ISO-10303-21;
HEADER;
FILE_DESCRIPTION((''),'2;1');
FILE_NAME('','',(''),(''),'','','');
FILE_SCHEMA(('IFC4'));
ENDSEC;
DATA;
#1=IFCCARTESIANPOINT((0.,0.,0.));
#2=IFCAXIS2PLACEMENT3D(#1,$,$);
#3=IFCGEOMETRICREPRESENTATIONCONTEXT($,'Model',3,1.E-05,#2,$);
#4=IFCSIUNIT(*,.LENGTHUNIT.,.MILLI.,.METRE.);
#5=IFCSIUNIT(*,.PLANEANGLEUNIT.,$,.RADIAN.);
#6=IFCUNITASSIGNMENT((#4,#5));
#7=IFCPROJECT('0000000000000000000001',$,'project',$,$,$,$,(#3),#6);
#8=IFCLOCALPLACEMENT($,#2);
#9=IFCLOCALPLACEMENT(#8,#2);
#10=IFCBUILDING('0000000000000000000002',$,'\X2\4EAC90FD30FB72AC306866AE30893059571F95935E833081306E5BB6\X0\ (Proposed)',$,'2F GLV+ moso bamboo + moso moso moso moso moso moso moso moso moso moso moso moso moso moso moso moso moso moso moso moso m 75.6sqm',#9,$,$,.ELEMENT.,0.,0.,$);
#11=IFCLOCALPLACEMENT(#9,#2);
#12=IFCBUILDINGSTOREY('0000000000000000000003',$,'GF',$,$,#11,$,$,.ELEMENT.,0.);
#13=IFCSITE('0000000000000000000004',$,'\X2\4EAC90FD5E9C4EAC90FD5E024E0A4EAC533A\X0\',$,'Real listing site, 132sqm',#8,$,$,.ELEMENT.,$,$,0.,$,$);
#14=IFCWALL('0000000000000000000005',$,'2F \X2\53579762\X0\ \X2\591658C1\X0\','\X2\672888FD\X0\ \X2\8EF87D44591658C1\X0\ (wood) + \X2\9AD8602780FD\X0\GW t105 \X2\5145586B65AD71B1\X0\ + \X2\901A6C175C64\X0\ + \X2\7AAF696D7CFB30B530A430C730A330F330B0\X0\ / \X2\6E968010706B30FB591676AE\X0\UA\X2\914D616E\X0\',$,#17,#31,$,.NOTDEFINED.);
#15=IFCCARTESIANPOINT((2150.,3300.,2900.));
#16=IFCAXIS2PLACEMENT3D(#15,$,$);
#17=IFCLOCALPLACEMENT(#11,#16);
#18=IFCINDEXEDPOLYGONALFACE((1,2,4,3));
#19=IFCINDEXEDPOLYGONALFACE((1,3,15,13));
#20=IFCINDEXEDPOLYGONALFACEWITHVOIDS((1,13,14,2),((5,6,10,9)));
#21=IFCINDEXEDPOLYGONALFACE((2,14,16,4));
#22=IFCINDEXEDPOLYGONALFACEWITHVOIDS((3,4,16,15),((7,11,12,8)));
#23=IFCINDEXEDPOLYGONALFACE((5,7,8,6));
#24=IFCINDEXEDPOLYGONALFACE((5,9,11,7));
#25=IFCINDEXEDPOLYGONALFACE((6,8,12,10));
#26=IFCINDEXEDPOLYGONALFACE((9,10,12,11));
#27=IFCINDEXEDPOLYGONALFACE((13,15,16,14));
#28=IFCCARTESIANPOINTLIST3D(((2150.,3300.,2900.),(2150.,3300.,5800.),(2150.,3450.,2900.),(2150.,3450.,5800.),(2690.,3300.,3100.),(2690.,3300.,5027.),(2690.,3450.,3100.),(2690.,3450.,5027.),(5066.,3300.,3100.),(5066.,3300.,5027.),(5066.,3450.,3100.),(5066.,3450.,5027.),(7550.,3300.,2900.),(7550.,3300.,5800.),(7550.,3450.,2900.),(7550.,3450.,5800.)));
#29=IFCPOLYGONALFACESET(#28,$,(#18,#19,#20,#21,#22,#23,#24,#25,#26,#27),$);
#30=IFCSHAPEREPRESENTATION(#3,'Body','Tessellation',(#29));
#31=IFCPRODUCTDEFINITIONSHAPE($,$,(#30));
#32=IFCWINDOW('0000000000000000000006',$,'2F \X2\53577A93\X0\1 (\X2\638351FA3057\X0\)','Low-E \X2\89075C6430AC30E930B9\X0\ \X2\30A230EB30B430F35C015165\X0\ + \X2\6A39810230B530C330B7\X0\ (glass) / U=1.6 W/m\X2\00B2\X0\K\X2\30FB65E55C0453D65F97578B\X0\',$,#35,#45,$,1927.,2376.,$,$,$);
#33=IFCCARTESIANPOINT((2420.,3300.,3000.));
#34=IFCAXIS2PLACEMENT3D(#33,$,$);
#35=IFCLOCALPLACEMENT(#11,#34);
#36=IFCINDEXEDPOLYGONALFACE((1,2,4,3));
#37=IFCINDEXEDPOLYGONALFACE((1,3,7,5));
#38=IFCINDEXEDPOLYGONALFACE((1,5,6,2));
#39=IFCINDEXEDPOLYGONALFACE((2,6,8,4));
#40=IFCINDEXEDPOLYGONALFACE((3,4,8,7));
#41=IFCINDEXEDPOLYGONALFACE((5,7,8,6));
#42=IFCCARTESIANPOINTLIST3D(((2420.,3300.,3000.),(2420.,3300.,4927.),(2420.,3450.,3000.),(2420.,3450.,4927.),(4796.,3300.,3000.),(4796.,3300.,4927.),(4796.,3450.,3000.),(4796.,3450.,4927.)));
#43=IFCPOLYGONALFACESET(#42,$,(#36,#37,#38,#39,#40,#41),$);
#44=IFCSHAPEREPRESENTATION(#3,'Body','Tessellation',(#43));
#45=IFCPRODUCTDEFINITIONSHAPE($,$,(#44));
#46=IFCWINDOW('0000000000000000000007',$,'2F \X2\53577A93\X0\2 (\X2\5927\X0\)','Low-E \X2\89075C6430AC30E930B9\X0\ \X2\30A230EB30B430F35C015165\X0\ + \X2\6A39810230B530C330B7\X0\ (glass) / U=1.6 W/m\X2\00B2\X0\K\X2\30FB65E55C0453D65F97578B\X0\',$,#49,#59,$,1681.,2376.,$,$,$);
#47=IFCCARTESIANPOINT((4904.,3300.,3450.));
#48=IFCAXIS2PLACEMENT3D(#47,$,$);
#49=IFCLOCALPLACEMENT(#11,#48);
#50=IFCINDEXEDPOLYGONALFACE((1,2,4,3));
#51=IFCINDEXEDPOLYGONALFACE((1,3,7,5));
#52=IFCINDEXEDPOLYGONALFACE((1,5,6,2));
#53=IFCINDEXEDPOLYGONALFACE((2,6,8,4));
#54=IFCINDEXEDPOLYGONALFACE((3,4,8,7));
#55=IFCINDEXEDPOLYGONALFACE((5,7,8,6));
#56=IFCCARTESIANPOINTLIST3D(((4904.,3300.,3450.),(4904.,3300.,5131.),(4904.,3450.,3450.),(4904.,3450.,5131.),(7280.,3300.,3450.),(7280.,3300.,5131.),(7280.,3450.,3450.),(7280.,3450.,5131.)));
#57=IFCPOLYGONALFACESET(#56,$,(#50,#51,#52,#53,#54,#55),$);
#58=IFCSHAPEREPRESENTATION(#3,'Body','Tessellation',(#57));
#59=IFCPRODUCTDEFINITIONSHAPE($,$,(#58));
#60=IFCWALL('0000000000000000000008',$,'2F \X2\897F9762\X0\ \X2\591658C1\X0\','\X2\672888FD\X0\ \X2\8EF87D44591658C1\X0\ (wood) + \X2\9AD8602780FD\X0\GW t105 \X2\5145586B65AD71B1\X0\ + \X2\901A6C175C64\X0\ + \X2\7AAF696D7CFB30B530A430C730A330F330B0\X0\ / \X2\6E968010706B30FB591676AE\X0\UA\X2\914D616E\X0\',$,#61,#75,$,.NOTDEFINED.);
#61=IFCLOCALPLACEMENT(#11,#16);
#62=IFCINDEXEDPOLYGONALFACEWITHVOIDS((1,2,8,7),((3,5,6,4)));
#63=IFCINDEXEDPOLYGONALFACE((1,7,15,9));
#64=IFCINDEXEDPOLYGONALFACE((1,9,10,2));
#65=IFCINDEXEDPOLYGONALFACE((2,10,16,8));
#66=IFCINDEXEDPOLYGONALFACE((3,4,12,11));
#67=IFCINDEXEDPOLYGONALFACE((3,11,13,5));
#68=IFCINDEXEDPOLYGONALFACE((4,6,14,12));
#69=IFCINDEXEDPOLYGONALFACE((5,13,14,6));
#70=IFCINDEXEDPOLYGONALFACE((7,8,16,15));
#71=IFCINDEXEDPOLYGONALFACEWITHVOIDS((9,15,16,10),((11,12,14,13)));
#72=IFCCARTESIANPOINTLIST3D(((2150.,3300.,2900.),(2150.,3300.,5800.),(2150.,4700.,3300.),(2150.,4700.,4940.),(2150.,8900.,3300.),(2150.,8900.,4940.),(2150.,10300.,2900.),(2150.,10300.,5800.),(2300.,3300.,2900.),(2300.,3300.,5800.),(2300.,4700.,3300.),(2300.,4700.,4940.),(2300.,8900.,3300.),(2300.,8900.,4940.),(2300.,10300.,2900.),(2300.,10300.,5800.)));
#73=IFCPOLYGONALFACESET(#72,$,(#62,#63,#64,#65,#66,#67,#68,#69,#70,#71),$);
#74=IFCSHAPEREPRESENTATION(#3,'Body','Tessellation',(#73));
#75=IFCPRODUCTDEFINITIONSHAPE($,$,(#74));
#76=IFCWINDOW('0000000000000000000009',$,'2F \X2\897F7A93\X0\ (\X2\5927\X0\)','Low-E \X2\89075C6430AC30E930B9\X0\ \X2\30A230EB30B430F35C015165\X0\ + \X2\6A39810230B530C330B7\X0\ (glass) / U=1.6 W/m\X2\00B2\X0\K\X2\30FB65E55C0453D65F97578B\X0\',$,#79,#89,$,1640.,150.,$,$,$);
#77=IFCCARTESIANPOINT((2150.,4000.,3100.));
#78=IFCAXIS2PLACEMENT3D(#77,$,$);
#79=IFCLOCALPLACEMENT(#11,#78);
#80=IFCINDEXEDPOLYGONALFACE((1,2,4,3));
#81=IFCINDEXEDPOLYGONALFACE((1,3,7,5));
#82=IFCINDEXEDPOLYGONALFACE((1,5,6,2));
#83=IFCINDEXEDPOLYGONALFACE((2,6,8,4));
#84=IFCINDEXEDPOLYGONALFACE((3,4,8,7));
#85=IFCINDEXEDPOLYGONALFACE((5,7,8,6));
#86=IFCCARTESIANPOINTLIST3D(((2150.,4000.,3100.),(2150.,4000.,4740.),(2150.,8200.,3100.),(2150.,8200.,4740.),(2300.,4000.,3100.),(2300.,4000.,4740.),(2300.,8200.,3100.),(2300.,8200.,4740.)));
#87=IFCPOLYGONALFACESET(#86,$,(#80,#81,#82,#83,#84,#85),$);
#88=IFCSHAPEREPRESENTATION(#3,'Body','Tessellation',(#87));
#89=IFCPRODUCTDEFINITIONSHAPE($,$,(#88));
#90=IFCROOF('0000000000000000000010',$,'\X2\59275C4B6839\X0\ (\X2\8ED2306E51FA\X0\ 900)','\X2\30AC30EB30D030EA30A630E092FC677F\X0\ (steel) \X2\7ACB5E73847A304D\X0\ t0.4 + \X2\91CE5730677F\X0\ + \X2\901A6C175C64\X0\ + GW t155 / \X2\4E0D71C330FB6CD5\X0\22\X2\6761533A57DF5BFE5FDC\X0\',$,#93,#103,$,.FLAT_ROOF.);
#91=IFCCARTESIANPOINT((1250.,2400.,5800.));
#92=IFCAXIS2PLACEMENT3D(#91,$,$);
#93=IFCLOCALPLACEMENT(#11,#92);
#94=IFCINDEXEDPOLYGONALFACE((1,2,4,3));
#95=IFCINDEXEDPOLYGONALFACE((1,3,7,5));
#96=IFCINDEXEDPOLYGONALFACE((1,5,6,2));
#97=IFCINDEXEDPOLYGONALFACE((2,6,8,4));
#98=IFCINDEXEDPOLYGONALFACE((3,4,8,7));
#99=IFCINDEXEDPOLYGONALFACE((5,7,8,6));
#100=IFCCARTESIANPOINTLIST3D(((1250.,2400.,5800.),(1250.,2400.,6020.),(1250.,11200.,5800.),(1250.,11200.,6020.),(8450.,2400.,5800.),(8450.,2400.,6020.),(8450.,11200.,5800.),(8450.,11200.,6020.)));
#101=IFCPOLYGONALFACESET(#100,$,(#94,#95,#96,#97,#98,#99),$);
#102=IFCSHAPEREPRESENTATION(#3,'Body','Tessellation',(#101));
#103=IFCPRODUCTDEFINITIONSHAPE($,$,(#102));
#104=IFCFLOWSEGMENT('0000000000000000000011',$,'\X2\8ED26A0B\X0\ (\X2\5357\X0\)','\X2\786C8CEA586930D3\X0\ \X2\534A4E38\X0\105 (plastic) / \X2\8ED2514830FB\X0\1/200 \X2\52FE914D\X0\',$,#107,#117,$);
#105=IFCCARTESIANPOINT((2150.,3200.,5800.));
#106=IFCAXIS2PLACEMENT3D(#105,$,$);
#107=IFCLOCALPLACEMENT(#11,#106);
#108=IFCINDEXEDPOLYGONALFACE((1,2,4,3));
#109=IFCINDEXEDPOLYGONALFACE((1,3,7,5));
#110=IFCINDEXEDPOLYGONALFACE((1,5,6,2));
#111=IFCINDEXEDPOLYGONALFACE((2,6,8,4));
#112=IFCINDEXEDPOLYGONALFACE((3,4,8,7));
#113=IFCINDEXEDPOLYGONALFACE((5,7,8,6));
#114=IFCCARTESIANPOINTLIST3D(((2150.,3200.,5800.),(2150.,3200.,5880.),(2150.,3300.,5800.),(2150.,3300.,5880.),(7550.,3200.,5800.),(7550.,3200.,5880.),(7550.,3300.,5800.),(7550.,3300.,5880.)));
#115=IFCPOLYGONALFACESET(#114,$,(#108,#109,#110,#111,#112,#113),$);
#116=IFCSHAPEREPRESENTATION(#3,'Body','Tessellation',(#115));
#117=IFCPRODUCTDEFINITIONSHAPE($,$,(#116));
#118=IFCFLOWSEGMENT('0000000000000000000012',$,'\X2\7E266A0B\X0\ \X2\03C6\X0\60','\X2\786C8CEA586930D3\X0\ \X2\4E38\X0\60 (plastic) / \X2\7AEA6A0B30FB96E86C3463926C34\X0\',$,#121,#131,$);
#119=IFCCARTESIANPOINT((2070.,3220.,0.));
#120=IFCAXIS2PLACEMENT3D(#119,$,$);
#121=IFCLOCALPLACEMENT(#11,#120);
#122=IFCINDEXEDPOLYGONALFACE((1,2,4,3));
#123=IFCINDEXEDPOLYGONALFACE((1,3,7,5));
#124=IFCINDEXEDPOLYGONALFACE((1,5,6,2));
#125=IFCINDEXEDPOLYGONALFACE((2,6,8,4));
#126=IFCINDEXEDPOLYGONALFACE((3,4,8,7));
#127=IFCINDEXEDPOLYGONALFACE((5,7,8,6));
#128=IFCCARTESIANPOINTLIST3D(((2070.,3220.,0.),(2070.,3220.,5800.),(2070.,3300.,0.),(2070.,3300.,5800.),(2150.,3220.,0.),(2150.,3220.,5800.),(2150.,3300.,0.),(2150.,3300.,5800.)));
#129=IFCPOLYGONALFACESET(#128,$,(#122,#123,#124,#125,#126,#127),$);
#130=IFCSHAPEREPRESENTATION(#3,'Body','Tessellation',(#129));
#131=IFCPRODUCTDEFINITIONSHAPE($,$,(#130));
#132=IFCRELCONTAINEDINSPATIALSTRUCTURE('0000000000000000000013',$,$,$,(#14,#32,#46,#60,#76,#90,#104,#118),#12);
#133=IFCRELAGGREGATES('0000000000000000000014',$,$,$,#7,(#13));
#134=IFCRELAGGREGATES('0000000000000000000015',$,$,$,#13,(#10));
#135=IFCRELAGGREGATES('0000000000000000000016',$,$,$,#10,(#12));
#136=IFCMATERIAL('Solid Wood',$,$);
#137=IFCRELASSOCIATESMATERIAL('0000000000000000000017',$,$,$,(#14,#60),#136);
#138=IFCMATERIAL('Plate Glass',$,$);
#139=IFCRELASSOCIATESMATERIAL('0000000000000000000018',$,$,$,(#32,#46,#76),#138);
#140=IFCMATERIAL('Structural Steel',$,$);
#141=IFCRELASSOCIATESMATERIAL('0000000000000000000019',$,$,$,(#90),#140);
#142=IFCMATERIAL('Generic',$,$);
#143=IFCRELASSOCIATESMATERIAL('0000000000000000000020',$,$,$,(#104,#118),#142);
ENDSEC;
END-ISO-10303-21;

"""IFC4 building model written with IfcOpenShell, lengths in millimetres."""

from ifc_helpers import new_model, si_unit, frame, frame_2d, origin, place, context, project, spatial, rectangle, extrude, material, element, fill, save


model = new_model("IFC4")

# Units and contexts
model_context = context("Model", 3, precision=1e-05, world=origin())
ifc_project = project(units=[si_unit("LENGTHUNIT", "METRE", prefix="MILLI"), si_unit("PLANEANGLEUNIT", "RADIAN")], contexts=[model_context])

# Site, building, storey
site_placement = place(None, origin())
site = spatial("IfcSite", under=ifc_project, at=site_placement, Name="京都府京都市上京区", ObjectType="Real listing site, 132sqm", CompositionType="ELEMENT", RefElevation=0.0)
building_placement = place(site_placement, origin())
building = spatial("IfcBuilding", under=site, at=building_placement, Name="京都・犬と暮らす土間広めの家 (Proposed)", ObjectType="2F GLV+ moso bamboo + moso moso moso moso moso moso moso moso moso moso moso moso moso moso moso moso moso moso moso moso m 75.6sqm", CompositionType="ELEMENT", ElevationOfRefHeight=0.0, ElevationOfTerrain=0.0)
storey_placement = place(building_placement, origin())
storey = spatial("IfcBuildingStorey", under=building, at=storey_placement, Name="GF", CompositionType="ELEMENT", Elevation=0.0)

# Shared definitions
ifc_material_1 = material(Name="Solid Wood")

# Shared definitions
ifc_material_2 = material(Name="Plate Glass")

# Wall, openings, windows
wall_1_placement = place(storey_placement, frame((2150.0, 3300.0, 2900.0)))
wall_1 = element("IfcWall", 1, at=wall_1_placement, inside=storey, material=ifc_material_1, Name="2F 南面 外壁", Description="木製 軸組外壁 (wood) + 高性能GW t105 充填断熱 + 通気層 + 窯業系サイディング / 準耐火・外皮UA配慮", PredefinedType="NOTDEFINED", context=model_context, shape_type="SweptSolid", body=[
    extrude(rectangle(XDim=5400.0, YDim=150.0, at=frame_2d((2700.0, 75.0))), frame((2150.0, 3300.0, 2900.0)), (0.0, 0.0, 1.0), 2900.0),
])
opening_1_placement = place(storey_placement, frame((2420.0, 3300.0, 3000.0)))
opening_1 = element("IfcOpeningElement", 2, at=opening_1_placement, cuts=wall_1, PredefinedType="NOTDEFINED", context=model_context, shape_type="SweptSolid", body=[
    extrude(rectangle(XDim=2376.0, YDim=150.0, at=frame_2d((1188.0, 75.0))), frame((2420.0, 3300.0, 3000.0)), (0.0, 0.0, 1.0), 1927.0),
])
opening_2_placement = place(storey_placement, frame((4904.0, 3300.0, 3450.0)))
opening_2 = element("IfcOpeningElement", 3, at=opening_2_placement, cuts=wall_1, PredefinedType="NOTDEFINED", context=model_context, shape_type="SweptSolid", body=[
    extrude(rectangle(XDim=2376.0, YDim=150.0, at=frame_2d((1188.0, 75.0))), frame((4904.0, 3300.0, 3450.0)), (0.0, 0.0, 1.0), 1681.0),
])
window_1_placement = place(storey_placement, frame((2420.0, 3300.0, 3000.0)))
window_1 = element("IfcWindow", 4, at=window_1_placement, inside=storey, material=ifc_material_2, Name="2F 南窓1 (掃出し)", Description="Low-E 複層ガラス アルゴン封入 + 樹脂サッシ (glass) / U=1.6 W/m²K・日射取得型", OverallHeight=1927.0, OverallWidth=2376.0, context=model_context, shape_type="SweptSolid", body=[
    extrude(rectangle(XDim=2376.0, YDim=150.0, at=frame_2d((1188.0, 75.0))), frame((2420.0, 3300.0, 3000.0)), (0.0, 0.0, 1.0), 1927.0),
])
fill(opening_1, window_1)
window_2_placement = place(storey_placement, frame((4904.0, 3300.0, 3450.0)))
window_2 = element("IfcWindow", 5, at=window_2_placement, inside=storey, material=ifc_material_2, Name="2F 南窓2 (大)", Description="Low-E 複層ガラス アルゴン封入 + 樹脂サッシ (glass) / U=1.6 W/m²K・日射取得型", OverallHeight=1681.0, OverallWidth=2376.0, context=model_context, shape_type="SweptSolid", body=[
    extrude(rectangle(XDim=2376.0, YDim=150.0, at=frame_2d((1188.0, 75.0))), frame((4904.0, 3300.0, 3450.0)), (0.0, 0.0, 1.0), 1681.0),
])
fill(opening_2, window_2)

# Wall, opening, window
wall_2_placement = place(storey_placement, frame((2150.0, 3300.0, 2900.0)))
wall_2 = element("IfcWall", 6, at=wall_2_placement, inside=storey, material=ifc_material_1, Name="2F 西面 外壁", Description="木製 軸組外壁 (wood) + 高性能GW t105 充填断熱 + 通気層 + 窯業系サイディング / 準耐火・外皮UA配慮", PredefinedType="NOTDEFINED", context=model_context, shape_type="SweptSolid", body=[
    extrude(rectangle(XDim=150.0, YDim=7000.0, at=frame_2d((75.0, 3500.0))), frame((2150.0, 3300.0, 2900.0)), (0.0, 0.0, 1.0), 2900.0),
])
opening_3_placement = place(storey_placement, frame((2150.0, 4000.0, 3100.0)))
opening_3 = element("IfcOpeningElement", 7, at=opening_3_placement, cuts=wall_2, PredefinedType="NOTDEFINED", context=model_context, shape_type="SweptSolid", body=[
    extrude(rectangle(XDim=150.0, YDim=4200.0, at=frame_2d((75.0, 2100.0))), frame((2150.0, 4000.0, 3100.0)), (0.0, 0.0, 1.0), 1640.0),
])
window_3_placement = place(storey_placement, frame((2150.0, 4000.0, 3100.0)))
window_3 = element("IfcWindow", 8, at=window_3_placement, inside=storey, material=ifc_material_2, Name="2F 西窓 (大)", Description="Low-E 複層ガラス アルゴン封入 + 樹脂サッシ (glass) / U=1.6 W/m²K・日射取得型", OverallHeight=1640.0, OverallWidth=150.0, context=model_context, shape_type="SweptSolid", body=[
    extrude(rectangle(XDim=150.0, YDim=4200.0, at=frame_2d((75.0, 2100.0))), frame((2150.0, 4000.0, 3100.0)), (0.0, 0.0, 1.0), 1640.0),
])
fill(opening_3, window_3)

# Roof
ifc_material_3 = material(Name="Structural Steel")
roof_placement = place(storey_placement, frame((1250.0, 2400.0, 5800.0)))
element("IfcRoof", 9, at=roof_placement, inside=storey, material=ifc_material_3, Name="大屋根 (軒の出 900)", Description="ガルバリウム鋼板 (steel) 立平葺き t0.4 + 野地板 + 通気層 + GW t155 / 不燃・法22条区域対応", PredefinedType="FLAT_ROOF", context=model_context, shape_type="SweptSolid", body=[
    extrude(rectangle(XDim=7200.0, YDim=8800.0, at=frame_2d((3600.0, 4400.0))), frame((1250.0, 2400.0, 5800.0)), (0.0, 0.0, 1.0), 220.0),
])

# Flow segments
ifc_material_4 = material(Name="Generic")
flow_segment_1_placement = place(storey_placement, frame((2150.0, 3200.0, 5800.0)))
element("IfcFlowSegment", 10, at=flow_segment_1_placement, inside=storey, material=ifc_material_4, Name="軒樋 (南)", Description="硬質塩ビ 半丸105 (plastic) / 軒先・1/200 勾配", context=model_context, shape_type="SweptSolid", body=[
    extrude(rectangle(XDim=5400.0, YDim=100.0, at=frame_2d((2700.0, 50.0))), frame((2150.0, 3200.0, 5800.0)), (0.0, 0.0, 1.0), 80.0),
])
flow_segment_2_placement = place(storey_placement, frame((2070.0, 3220.0, 0.0)))
element("IfcFlowSegment", 11, at=flow_segment_2_placement, inside=storey, material=ifc_material_4, Name="縦樋 φ60", Description="硬質塩ビ 丸60 (plastic) / 竪樋・雨水排水", context=model_context, shape_type="SweptSolid", body=[
    extrude(rectangle(XDim=80.0, YDim=80.0, at=frame_2d((40.0, 40.0))), frame((2070.0, 3220.0, 0.0)), (0.0, 0.0, 1.0), 5800.0),
])

save(model, "model.ifc")
